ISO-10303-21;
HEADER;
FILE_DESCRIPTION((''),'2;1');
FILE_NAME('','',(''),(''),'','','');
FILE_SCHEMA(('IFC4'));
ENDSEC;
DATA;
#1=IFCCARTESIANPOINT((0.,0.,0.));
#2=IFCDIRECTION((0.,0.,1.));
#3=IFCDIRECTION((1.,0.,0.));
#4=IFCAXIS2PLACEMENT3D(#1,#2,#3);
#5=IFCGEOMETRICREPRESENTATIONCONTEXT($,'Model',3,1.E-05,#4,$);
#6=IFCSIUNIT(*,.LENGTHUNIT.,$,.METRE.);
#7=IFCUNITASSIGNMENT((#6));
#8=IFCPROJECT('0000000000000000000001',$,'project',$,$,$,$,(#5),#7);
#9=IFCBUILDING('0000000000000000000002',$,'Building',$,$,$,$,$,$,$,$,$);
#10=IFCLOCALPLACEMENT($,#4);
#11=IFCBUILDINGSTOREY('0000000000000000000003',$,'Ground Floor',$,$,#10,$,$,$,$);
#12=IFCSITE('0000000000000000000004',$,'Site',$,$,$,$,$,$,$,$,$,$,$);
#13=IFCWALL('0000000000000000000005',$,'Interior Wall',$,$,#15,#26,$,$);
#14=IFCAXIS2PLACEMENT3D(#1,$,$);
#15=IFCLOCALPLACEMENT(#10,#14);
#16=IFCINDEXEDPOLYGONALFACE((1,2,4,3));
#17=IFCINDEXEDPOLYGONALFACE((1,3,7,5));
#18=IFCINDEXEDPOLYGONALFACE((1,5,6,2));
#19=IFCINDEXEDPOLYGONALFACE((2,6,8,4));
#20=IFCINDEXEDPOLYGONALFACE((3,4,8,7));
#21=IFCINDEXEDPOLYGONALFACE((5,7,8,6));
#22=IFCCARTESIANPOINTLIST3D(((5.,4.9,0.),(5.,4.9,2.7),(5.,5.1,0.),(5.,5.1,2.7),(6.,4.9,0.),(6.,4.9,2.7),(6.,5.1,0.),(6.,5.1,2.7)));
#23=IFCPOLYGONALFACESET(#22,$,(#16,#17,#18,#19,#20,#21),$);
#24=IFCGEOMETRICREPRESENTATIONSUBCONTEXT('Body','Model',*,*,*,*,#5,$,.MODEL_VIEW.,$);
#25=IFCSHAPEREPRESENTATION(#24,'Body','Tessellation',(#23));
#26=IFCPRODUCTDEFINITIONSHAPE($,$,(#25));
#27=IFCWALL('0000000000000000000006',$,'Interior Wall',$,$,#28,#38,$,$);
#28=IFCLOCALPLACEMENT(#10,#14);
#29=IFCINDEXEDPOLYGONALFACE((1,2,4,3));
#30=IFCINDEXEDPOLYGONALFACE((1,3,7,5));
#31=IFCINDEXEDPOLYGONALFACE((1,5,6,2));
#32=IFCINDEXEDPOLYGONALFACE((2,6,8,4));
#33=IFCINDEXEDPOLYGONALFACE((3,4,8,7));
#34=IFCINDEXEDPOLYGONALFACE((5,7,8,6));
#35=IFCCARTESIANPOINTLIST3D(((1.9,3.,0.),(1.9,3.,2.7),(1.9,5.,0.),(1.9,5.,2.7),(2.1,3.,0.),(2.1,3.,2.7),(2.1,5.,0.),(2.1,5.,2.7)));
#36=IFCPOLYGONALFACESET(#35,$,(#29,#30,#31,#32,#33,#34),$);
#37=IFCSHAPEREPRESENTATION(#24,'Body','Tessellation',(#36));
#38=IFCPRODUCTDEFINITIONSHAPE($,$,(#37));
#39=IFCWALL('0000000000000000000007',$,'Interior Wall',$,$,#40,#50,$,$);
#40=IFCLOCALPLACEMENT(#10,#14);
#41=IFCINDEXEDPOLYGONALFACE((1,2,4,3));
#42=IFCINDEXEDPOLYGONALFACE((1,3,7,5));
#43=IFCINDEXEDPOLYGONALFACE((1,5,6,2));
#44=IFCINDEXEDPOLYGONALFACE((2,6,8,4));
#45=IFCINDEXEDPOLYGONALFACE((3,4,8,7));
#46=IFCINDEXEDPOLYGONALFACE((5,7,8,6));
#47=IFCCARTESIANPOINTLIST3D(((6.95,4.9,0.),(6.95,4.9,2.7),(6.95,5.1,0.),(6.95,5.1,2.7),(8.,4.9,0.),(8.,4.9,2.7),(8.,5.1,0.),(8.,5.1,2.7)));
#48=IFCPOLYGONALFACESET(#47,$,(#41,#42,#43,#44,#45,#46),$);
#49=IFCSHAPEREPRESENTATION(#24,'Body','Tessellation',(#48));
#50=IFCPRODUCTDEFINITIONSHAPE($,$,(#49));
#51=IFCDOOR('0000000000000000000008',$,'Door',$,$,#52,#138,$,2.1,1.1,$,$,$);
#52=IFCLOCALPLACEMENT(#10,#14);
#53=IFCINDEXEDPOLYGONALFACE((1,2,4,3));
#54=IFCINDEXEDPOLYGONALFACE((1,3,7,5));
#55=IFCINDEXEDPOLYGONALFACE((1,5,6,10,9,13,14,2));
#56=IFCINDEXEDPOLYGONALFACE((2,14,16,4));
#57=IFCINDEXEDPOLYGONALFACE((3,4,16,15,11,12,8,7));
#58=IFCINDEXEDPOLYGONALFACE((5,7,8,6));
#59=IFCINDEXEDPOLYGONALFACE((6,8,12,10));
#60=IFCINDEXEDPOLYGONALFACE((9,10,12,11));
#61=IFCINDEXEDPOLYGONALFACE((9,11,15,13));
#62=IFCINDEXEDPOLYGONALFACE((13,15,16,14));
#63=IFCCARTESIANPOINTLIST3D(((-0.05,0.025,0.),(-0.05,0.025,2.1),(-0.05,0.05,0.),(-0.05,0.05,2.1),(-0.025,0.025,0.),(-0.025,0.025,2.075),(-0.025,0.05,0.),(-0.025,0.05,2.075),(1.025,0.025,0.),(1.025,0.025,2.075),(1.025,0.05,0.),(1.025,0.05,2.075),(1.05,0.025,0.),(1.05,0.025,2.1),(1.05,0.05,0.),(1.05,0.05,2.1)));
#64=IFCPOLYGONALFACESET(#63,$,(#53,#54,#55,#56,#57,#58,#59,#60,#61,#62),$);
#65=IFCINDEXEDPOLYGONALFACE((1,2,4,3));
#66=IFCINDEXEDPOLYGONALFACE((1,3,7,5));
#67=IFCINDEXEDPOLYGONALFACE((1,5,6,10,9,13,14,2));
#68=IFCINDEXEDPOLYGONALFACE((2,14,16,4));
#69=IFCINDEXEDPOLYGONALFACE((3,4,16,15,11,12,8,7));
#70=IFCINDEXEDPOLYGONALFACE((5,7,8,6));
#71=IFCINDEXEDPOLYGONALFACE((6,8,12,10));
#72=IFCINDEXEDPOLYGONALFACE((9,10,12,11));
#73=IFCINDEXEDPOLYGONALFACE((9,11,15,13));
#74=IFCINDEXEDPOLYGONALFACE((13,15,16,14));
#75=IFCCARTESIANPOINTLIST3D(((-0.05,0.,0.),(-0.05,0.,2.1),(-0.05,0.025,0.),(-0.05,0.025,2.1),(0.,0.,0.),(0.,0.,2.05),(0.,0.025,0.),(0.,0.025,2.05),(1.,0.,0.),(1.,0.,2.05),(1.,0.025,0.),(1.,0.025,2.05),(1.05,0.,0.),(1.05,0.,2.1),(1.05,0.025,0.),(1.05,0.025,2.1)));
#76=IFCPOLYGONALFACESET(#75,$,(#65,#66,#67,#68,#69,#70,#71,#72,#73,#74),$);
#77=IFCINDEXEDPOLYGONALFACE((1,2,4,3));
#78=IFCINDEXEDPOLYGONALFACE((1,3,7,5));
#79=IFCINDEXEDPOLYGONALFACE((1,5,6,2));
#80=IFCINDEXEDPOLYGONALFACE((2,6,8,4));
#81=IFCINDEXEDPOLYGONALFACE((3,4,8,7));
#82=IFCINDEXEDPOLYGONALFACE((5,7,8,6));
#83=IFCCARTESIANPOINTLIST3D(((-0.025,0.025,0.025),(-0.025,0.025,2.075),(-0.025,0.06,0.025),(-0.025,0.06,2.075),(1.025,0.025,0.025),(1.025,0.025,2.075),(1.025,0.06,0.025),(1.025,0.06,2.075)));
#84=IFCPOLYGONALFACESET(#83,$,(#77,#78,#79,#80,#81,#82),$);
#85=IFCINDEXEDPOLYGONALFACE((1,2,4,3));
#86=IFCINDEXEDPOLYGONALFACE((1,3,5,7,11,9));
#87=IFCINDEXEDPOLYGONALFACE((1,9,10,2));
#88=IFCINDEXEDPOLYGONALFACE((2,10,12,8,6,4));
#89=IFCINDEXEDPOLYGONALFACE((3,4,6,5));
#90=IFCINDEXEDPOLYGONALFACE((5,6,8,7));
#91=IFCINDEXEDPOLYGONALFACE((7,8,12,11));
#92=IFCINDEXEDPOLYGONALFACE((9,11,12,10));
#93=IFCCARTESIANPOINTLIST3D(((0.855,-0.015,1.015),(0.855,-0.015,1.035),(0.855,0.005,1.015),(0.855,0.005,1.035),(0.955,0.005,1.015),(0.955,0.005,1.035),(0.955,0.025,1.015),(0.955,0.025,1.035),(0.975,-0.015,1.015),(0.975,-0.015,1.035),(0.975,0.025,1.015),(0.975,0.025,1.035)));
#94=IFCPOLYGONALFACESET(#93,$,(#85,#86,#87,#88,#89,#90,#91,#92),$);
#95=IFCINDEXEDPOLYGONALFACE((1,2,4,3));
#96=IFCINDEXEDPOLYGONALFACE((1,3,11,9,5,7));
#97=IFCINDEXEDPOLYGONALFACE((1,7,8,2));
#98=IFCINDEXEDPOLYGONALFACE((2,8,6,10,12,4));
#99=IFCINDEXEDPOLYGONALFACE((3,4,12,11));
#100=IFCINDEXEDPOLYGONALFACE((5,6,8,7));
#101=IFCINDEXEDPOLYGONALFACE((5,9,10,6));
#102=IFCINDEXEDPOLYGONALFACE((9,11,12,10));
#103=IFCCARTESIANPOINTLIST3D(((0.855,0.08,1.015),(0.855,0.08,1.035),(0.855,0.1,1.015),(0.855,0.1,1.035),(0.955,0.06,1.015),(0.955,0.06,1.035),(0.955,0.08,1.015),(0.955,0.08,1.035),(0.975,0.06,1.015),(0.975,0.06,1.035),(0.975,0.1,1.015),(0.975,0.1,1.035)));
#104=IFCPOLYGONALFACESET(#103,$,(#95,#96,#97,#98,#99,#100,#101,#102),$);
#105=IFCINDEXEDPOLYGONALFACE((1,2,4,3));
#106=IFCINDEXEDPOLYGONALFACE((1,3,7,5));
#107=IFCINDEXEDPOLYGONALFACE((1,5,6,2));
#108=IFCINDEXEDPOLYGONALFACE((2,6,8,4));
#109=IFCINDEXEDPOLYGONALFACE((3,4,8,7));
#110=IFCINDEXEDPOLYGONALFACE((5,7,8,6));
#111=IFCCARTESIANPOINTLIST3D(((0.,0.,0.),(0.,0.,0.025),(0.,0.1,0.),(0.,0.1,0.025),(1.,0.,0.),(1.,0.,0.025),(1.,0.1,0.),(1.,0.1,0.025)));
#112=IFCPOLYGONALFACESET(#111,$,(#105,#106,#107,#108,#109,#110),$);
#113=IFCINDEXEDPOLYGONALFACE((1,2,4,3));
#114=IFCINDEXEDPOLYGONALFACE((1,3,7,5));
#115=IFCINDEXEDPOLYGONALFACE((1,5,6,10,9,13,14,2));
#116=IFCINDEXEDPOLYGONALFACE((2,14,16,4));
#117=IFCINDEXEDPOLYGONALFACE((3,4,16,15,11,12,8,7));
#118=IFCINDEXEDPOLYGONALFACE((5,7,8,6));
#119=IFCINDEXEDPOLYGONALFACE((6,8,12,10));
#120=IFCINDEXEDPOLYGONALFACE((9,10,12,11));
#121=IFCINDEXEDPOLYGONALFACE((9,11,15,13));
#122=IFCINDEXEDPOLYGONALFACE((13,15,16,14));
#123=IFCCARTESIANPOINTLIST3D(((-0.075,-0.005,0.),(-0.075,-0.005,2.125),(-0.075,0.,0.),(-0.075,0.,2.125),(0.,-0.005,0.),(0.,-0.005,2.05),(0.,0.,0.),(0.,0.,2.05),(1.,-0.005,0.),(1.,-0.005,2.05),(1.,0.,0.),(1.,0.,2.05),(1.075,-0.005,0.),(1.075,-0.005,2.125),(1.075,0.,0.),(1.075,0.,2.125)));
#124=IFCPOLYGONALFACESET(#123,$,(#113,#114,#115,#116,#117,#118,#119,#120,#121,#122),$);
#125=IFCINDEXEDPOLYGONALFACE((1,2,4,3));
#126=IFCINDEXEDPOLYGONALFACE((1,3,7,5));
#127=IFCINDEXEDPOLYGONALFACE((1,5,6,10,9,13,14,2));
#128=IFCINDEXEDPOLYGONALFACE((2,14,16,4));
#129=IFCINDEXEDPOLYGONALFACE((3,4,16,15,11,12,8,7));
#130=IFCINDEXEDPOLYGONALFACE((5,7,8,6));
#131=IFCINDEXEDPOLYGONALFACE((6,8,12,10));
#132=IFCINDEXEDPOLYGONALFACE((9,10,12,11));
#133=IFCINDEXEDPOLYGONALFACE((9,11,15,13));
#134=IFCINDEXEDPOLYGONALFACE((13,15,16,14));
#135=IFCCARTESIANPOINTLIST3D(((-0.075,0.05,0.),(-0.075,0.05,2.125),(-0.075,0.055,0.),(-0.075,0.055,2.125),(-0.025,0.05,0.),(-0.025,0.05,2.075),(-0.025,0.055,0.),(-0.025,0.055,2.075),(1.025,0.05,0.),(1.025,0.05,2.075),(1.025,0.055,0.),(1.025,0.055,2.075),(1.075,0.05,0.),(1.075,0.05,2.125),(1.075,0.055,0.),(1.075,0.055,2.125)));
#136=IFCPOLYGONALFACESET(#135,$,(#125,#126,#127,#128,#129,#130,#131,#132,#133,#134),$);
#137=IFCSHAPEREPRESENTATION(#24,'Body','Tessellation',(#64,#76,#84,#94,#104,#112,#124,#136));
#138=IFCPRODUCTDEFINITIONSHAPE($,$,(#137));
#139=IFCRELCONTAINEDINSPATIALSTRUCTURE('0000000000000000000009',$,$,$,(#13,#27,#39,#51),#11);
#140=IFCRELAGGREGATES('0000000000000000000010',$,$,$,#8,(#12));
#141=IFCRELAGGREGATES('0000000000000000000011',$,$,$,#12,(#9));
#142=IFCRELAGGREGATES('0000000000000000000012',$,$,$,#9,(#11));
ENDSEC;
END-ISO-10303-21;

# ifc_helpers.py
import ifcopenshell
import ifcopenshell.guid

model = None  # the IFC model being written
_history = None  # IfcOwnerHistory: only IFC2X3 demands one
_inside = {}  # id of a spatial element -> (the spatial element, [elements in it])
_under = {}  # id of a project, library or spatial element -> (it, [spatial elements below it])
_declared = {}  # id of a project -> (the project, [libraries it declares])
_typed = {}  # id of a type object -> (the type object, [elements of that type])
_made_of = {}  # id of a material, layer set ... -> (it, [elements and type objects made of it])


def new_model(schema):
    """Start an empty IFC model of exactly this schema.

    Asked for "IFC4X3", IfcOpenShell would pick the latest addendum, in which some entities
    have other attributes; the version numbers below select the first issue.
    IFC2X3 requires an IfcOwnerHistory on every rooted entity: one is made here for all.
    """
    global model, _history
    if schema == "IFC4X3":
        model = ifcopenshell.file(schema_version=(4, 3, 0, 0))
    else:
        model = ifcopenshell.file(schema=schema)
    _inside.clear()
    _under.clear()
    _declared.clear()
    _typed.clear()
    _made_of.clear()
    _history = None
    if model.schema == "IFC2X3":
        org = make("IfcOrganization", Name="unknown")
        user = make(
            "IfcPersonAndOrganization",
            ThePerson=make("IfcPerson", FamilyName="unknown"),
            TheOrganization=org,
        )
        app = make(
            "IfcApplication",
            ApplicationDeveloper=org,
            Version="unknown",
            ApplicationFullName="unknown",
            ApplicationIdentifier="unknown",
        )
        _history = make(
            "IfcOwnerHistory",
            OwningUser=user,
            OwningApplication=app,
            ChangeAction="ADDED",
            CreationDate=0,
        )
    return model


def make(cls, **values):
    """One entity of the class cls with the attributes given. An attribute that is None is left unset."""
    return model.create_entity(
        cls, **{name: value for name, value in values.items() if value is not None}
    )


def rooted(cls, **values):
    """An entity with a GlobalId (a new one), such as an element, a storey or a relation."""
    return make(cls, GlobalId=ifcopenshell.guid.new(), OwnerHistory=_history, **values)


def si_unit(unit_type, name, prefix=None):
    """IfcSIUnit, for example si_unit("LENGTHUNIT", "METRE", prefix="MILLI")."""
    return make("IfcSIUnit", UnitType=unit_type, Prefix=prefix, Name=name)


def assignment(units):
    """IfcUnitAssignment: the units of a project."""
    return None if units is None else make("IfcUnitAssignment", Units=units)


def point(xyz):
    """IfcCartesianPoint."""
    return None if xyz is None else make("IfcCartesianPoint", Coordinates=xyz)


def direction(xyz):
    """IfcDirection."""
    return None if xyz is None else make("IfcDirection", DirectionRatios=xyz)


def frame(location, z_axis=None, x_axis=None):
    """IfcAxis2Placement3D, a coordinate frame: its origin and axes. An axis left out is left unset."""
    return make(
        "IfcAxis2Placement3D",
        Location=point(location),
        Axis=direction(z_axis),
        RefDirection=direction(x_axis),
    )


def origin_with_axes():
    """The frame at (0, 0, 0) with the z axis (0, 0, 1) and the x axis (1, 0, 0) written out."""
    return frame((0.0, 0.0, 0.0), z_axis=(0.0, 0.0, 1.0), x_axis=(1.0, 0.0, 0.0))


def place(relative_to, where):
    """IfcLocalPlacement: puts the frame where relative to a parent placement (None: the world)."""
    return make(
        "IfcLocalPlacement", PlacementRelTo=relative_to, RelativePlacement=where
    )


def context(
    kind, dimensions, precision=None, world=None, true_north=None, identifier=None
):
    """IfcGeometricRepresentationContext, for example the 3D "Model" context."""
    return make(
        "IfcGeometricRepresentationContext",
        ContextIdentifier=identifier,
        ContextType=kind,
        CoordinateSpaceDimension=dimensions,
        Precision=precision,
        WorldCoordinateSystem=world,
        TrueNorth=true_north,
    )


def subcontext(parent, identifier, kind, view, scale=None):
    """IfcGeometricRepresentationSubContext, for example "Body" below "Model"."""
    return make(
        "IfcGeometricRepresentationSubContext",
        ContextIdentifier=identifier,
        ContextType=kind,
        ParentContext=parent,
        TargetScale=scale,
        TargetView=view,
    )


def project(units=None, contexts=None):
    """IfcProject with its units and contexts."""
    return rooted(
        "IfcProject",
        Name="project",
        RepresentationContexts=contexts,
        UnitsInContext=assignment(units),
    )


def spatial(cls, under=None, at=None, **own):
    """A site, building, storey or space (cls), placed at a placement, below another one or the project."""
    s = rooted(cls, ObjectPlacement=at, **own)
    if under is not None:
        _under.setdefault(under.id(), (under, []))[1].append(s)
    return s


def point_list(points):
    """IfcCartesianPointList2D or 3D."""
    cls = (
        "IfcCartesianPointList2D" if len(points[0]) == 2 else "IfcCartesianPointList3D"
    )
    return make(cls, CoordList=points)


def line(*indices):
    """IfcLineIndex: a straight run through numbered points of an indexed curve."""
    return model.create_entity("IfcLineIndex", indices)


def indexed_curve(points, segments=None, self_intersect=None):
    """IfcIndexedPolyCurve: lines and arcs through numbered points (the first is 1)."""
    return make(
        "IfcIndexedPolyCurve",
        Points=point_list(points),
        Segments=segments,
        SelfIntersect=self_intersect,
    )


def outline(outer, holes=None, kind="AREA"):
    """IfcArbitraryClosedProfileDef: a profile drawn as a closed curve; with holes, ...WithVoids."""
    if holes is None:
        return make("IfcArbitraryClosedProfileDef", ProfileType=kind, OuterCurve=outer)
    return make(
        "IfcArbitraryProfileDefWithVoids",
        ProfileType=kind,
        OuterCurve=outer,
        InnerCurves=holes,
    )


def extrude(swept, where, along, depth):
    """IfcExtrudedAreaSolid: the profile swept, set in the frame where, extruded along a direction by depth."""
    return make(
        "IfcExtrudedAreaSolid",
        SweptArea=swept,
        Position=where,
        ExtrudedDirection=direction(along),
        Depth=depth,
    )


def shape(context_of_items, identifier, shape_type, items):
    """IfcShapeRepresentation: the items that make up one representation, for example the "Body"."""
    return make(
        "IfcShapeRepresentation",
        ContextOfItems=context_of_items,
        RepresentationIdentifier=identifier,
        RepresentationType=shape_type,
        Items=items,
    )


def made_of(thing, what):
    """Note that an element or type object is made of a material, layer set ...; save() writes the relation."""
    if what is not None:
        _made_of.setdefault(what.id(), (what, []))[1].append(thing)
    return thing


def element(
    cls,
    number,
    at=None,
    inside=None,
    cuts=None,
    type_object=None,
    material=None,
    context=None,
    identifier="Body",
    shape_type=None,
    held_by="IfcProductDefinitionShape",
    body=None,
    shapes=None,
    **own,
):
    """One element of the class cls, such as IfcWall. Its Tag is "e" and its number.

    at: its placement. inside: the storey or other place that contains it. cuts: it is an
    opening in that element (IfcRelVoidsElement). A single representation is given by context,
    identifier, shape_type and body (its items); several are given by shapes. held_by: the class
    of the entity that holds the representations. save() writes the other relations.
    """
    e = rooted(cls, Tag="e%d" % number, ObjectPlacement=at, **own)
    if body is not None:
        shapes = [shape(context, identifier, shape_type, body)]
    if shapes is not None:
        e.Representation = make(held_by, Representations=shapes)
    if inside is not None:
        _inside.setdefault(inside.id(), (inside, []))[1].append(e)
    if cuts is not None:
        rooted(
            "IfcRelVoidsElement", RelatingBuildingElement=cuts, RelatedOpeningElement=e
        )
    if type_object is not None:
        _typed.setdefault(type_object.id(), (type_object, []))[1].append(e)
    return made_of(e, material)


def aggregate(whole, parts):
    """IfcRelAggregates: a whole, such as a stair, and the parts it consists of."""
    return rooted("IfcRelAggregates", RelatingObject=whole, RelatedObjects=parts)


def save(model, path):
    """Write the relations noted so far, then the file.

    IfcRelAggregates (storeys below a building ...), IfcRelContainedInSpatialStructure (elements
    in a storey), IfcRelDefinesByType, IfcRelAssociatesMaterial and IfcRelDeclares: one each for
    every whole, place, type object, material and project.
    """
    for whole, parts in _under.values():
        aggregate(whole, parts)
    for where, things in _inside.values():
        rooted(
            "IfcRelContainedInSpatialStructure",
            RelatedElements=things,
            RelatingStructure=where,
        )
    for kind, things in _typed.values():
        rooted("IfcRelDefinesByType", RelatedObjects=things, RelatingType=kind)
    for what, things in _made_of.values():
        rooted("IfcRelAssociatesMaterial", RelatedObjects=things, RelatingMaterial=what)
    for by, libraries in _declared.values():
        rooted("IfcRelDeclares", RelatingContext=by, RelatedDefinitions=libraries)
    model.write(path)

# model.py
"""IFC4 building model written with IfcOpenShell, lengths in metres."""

from ifc_helpers import new_model, si_unit, frame, origin_with_axes, place, context, subcontext, project, spatial, line, indexed_curve, outline, extrude, element, save


model = new_model("IFC4")

# Units and contexts
model_context = context("Model", 3, precision=1e-05, world=origin_with_axes())
body_context = subcontext(model_context, "Body", "Model", "MODEL_VIEW")
ifc_project = project(units=[si_unit("LENGTHUNIT", "METRE")], contexts=[model_context])

# Site, building, storey
site = spatial("IfcSite", under=ifc_project, Name="Site")
building = spatial("IfcBuilding", under=site, Name="Building")
storey_placement = place(None, origin_with_axes())
storey = spatial("IfcBuildingStorey", under=building, at=storey_placement, Name="Ground Floor")

# Walls
wall_1_placement = place(storey_placement, frame((6.0, 5.0, 0.0), z_axis=(0.0, 0.0, 1.0), x_axis=(-1.0, 0.0, 0.0)))
element("IfcWall", 1, at=wall_1_placement, inside=storey, Name="Interior Wall", context=body_context, shape_type="SweptSolid", body=[
    extrude(outline(indexed_curve([(0.0, 0.0), (0.0, 0.2), (1.0, 0.2), (1.0, 0.0), (0.0, 0.0)], self_intersect=False)), frame((0.0, -0.1, 0.0), z_axis=(0.0, 0.0, 1.0), x_axis=(1.0, 0.0, 0.0)), (0.0, 0.0, 1.0), 2.7),
])
wall_2_placement = place(storey_placement, frame((2.0, 5.0, 0.0), z_axis=(0.0, 0.0, 1.0), x_axis=(0.0, -1.0, 0.0)))
element("IfcWall", 2, at=wall_2_placement, inside=storey, Name="Interior Wall", context=body_context, shape_type="SweptSolid", body=[
    extrude(outline(indexed_curve([(0.0, 0.0), (0.0, 0.2), (2.0, 0.2), (2.0, 0.0), (0.0, 0.0)], self_intersect=False)), frame((0.0, -0.1, 0.0), z_axis=(0.0, 0.0, 1.0), x_axis=(1.0, 0.0, 0.0)), (0.0, 0.0, 1.0), 2.7),
])
wall_3_placement = place(storey_placement, frame((8.0, 5.0, 0.0), z_axis=(0.0, 0.0, 1.0), x_axis=(-1.0, 0.0, 0.0)))
element("IfcWall", 3, at=wall_3_placement, inside=storey, Name="Interior Wall", context=body_context, shape_type="SweptSolid", body=[
    extrude(outline(indexed_curve([(0.0, 0.0), (0.0, 0.2), (1.05, 0.2), (1.05, 0.0), (0.0, 0.0)], self_intersect=False)), frame((0.0, -0.1, 0.0), z_axis=(0.0, 0.0, 1.0), x_axis=(1.0, 0.0, 0.0)), (0.0, 0.0, 1.0), 2.7),
])

# Door
door_1_placement = place(storey_placement, frame((-0.05, 0.0, 0.0), z_axis=(0.0, 0.0, 1.0), x_axis=(1.0, 0.0, 0.0)))
element("IfcDoor", 4, at=door_1_placement, inside=storey, Name="Door", OverallHeight=2.1, OverallWidth=1.1, context=body_context, shape_type="SweptSolid", body=[
    extrude(outline(indexed_curve([(0.0, 0.0), (0.0, 2.1), (1.1, 2.1), (1.1, 0.0), (1.075, 0.0), (1.075, 2.075), (0.025, 2.075), (0.025, 0.0)], segments=[line(1, 2, 3, 4, 5, 6, 7, 8, 1)])), frame((0.0, 0.025, 0.0), z_axis=(0.0, -1.0, 0.0), x_axis=(1.0, 0.0, 0.0)), (0.0, 0.0, -1.0), 0.025),
    extrude(outline(indexed_curve([(0.0, 0.0), (0.0, 2.1), (1.1, 2.1), (1.1, 0.0), (1.05, 0.0), (1.05, 2.05), (0.05, 2.05), (0.05, 0.0)], segments=[line(1, 2, 3, 4, 5, 6, 7, 8, 1)])), frame((0.0, 0.0, 0.0), z_axis=(0.0, -1.0, 0.0), x_axis=(1.0, 0.0, 0.0)), (0.0, 0.0, -1.0), 0.025),
    extrude(outline(indexed_curve([(0.0, 0.0), (1.05, 0.0), (1.05, 0.035), (0.0, 0.035)], segments=[line(1, 2, 3, 4, 1)])), frame((0.025, 0.025, 0.025), z_axis=(0.0, 0.0, 1.0), x_axis=(1.0, 0.0, 0.0)), (0.0, 0.0, 1.0), 2.05),
    extrude(outline(indexed_curve([(0.0, 0.0), (0.0, -0.04), (-0.12, -0.04), (-0.12, -0.02), (-0.02, -0.02), (-0.02, 0.0)], segments=[line(1, 2, 3, 4, 5, 6, 1)])), frame((1.025, 0.025, 1.015), z_axis=(0.0, 0.0, 1.0), x_axis=(1.0, 0.0, 0.0)), (0.0, 0.0, 1.0), 0.02),
    extrude(outline(indexed_curve([(0.0, 0.0), (0.0, 0.04), (-0.12, 0.04), (-0.12, 0.02), (-0.02, 0.02), (-0.02, 0.0)], segments=[line(1, 2, 3, 4, 5, 6, 1)])), frame((1.025, 0.06, 1.015), z_axis=(0.0, 0.0, 1.0), x_axis=(1.0, 0.0, 0.0)), (0.0, 0.0, 1.0), 0.02),
    extrude(outline(indexed_curve([(0.0, 0.0), (1.0, 0.0), (1.0, 0.1), (0.0, 0.1)], segments=[line(1, 2, 3, 4, 1)])), frame((0.05, 0.0, 0.0), z_axis=(0.0, 0.0, 1.0), x_axis=(1.0, 0.0, 0.0)), (0.0, 0.0, 1.0), 0.025),
    extrude(outline(indexed_curve([(0.0, 0.0), (0.0, 2.125), (1.15, 2.125), (1.15, 0.0), (1.075, 0.0), (1.075, 2.05), (0.075, 2.05), (0.075, 0.0)], segments=[line(1, 2, 3, 4, 5, 6, 7, 8, 1)])), frame((-0.025, -0.005, 0.0), z_axis=(0.0, -1.0, 0.0), x_axis=(1.0, 0.0, 0.0)), (0.0, 0.0, -1.0), 0.005),
    extrude(outline(indexed_curve([(0.0, 0.0), (0.0, 2.125), (1.15, 2.125), (1.15, 0.0), (1.1, 0.0), (1.1, 2.075), (0.05, 2.075), (0.05, 0.0)], segments=[line(1, 2, 3, 4, 5, 6, 7, 8, 1)])), frame((-0.025, 0.05, 0.0), z_axis=(0.0, -1.0, 0.0), x_axis=(1.0, 0.0, 0.0)), (0.0, 0.0, -1.0), 0.005),
])

save(model, "model.ifc")
